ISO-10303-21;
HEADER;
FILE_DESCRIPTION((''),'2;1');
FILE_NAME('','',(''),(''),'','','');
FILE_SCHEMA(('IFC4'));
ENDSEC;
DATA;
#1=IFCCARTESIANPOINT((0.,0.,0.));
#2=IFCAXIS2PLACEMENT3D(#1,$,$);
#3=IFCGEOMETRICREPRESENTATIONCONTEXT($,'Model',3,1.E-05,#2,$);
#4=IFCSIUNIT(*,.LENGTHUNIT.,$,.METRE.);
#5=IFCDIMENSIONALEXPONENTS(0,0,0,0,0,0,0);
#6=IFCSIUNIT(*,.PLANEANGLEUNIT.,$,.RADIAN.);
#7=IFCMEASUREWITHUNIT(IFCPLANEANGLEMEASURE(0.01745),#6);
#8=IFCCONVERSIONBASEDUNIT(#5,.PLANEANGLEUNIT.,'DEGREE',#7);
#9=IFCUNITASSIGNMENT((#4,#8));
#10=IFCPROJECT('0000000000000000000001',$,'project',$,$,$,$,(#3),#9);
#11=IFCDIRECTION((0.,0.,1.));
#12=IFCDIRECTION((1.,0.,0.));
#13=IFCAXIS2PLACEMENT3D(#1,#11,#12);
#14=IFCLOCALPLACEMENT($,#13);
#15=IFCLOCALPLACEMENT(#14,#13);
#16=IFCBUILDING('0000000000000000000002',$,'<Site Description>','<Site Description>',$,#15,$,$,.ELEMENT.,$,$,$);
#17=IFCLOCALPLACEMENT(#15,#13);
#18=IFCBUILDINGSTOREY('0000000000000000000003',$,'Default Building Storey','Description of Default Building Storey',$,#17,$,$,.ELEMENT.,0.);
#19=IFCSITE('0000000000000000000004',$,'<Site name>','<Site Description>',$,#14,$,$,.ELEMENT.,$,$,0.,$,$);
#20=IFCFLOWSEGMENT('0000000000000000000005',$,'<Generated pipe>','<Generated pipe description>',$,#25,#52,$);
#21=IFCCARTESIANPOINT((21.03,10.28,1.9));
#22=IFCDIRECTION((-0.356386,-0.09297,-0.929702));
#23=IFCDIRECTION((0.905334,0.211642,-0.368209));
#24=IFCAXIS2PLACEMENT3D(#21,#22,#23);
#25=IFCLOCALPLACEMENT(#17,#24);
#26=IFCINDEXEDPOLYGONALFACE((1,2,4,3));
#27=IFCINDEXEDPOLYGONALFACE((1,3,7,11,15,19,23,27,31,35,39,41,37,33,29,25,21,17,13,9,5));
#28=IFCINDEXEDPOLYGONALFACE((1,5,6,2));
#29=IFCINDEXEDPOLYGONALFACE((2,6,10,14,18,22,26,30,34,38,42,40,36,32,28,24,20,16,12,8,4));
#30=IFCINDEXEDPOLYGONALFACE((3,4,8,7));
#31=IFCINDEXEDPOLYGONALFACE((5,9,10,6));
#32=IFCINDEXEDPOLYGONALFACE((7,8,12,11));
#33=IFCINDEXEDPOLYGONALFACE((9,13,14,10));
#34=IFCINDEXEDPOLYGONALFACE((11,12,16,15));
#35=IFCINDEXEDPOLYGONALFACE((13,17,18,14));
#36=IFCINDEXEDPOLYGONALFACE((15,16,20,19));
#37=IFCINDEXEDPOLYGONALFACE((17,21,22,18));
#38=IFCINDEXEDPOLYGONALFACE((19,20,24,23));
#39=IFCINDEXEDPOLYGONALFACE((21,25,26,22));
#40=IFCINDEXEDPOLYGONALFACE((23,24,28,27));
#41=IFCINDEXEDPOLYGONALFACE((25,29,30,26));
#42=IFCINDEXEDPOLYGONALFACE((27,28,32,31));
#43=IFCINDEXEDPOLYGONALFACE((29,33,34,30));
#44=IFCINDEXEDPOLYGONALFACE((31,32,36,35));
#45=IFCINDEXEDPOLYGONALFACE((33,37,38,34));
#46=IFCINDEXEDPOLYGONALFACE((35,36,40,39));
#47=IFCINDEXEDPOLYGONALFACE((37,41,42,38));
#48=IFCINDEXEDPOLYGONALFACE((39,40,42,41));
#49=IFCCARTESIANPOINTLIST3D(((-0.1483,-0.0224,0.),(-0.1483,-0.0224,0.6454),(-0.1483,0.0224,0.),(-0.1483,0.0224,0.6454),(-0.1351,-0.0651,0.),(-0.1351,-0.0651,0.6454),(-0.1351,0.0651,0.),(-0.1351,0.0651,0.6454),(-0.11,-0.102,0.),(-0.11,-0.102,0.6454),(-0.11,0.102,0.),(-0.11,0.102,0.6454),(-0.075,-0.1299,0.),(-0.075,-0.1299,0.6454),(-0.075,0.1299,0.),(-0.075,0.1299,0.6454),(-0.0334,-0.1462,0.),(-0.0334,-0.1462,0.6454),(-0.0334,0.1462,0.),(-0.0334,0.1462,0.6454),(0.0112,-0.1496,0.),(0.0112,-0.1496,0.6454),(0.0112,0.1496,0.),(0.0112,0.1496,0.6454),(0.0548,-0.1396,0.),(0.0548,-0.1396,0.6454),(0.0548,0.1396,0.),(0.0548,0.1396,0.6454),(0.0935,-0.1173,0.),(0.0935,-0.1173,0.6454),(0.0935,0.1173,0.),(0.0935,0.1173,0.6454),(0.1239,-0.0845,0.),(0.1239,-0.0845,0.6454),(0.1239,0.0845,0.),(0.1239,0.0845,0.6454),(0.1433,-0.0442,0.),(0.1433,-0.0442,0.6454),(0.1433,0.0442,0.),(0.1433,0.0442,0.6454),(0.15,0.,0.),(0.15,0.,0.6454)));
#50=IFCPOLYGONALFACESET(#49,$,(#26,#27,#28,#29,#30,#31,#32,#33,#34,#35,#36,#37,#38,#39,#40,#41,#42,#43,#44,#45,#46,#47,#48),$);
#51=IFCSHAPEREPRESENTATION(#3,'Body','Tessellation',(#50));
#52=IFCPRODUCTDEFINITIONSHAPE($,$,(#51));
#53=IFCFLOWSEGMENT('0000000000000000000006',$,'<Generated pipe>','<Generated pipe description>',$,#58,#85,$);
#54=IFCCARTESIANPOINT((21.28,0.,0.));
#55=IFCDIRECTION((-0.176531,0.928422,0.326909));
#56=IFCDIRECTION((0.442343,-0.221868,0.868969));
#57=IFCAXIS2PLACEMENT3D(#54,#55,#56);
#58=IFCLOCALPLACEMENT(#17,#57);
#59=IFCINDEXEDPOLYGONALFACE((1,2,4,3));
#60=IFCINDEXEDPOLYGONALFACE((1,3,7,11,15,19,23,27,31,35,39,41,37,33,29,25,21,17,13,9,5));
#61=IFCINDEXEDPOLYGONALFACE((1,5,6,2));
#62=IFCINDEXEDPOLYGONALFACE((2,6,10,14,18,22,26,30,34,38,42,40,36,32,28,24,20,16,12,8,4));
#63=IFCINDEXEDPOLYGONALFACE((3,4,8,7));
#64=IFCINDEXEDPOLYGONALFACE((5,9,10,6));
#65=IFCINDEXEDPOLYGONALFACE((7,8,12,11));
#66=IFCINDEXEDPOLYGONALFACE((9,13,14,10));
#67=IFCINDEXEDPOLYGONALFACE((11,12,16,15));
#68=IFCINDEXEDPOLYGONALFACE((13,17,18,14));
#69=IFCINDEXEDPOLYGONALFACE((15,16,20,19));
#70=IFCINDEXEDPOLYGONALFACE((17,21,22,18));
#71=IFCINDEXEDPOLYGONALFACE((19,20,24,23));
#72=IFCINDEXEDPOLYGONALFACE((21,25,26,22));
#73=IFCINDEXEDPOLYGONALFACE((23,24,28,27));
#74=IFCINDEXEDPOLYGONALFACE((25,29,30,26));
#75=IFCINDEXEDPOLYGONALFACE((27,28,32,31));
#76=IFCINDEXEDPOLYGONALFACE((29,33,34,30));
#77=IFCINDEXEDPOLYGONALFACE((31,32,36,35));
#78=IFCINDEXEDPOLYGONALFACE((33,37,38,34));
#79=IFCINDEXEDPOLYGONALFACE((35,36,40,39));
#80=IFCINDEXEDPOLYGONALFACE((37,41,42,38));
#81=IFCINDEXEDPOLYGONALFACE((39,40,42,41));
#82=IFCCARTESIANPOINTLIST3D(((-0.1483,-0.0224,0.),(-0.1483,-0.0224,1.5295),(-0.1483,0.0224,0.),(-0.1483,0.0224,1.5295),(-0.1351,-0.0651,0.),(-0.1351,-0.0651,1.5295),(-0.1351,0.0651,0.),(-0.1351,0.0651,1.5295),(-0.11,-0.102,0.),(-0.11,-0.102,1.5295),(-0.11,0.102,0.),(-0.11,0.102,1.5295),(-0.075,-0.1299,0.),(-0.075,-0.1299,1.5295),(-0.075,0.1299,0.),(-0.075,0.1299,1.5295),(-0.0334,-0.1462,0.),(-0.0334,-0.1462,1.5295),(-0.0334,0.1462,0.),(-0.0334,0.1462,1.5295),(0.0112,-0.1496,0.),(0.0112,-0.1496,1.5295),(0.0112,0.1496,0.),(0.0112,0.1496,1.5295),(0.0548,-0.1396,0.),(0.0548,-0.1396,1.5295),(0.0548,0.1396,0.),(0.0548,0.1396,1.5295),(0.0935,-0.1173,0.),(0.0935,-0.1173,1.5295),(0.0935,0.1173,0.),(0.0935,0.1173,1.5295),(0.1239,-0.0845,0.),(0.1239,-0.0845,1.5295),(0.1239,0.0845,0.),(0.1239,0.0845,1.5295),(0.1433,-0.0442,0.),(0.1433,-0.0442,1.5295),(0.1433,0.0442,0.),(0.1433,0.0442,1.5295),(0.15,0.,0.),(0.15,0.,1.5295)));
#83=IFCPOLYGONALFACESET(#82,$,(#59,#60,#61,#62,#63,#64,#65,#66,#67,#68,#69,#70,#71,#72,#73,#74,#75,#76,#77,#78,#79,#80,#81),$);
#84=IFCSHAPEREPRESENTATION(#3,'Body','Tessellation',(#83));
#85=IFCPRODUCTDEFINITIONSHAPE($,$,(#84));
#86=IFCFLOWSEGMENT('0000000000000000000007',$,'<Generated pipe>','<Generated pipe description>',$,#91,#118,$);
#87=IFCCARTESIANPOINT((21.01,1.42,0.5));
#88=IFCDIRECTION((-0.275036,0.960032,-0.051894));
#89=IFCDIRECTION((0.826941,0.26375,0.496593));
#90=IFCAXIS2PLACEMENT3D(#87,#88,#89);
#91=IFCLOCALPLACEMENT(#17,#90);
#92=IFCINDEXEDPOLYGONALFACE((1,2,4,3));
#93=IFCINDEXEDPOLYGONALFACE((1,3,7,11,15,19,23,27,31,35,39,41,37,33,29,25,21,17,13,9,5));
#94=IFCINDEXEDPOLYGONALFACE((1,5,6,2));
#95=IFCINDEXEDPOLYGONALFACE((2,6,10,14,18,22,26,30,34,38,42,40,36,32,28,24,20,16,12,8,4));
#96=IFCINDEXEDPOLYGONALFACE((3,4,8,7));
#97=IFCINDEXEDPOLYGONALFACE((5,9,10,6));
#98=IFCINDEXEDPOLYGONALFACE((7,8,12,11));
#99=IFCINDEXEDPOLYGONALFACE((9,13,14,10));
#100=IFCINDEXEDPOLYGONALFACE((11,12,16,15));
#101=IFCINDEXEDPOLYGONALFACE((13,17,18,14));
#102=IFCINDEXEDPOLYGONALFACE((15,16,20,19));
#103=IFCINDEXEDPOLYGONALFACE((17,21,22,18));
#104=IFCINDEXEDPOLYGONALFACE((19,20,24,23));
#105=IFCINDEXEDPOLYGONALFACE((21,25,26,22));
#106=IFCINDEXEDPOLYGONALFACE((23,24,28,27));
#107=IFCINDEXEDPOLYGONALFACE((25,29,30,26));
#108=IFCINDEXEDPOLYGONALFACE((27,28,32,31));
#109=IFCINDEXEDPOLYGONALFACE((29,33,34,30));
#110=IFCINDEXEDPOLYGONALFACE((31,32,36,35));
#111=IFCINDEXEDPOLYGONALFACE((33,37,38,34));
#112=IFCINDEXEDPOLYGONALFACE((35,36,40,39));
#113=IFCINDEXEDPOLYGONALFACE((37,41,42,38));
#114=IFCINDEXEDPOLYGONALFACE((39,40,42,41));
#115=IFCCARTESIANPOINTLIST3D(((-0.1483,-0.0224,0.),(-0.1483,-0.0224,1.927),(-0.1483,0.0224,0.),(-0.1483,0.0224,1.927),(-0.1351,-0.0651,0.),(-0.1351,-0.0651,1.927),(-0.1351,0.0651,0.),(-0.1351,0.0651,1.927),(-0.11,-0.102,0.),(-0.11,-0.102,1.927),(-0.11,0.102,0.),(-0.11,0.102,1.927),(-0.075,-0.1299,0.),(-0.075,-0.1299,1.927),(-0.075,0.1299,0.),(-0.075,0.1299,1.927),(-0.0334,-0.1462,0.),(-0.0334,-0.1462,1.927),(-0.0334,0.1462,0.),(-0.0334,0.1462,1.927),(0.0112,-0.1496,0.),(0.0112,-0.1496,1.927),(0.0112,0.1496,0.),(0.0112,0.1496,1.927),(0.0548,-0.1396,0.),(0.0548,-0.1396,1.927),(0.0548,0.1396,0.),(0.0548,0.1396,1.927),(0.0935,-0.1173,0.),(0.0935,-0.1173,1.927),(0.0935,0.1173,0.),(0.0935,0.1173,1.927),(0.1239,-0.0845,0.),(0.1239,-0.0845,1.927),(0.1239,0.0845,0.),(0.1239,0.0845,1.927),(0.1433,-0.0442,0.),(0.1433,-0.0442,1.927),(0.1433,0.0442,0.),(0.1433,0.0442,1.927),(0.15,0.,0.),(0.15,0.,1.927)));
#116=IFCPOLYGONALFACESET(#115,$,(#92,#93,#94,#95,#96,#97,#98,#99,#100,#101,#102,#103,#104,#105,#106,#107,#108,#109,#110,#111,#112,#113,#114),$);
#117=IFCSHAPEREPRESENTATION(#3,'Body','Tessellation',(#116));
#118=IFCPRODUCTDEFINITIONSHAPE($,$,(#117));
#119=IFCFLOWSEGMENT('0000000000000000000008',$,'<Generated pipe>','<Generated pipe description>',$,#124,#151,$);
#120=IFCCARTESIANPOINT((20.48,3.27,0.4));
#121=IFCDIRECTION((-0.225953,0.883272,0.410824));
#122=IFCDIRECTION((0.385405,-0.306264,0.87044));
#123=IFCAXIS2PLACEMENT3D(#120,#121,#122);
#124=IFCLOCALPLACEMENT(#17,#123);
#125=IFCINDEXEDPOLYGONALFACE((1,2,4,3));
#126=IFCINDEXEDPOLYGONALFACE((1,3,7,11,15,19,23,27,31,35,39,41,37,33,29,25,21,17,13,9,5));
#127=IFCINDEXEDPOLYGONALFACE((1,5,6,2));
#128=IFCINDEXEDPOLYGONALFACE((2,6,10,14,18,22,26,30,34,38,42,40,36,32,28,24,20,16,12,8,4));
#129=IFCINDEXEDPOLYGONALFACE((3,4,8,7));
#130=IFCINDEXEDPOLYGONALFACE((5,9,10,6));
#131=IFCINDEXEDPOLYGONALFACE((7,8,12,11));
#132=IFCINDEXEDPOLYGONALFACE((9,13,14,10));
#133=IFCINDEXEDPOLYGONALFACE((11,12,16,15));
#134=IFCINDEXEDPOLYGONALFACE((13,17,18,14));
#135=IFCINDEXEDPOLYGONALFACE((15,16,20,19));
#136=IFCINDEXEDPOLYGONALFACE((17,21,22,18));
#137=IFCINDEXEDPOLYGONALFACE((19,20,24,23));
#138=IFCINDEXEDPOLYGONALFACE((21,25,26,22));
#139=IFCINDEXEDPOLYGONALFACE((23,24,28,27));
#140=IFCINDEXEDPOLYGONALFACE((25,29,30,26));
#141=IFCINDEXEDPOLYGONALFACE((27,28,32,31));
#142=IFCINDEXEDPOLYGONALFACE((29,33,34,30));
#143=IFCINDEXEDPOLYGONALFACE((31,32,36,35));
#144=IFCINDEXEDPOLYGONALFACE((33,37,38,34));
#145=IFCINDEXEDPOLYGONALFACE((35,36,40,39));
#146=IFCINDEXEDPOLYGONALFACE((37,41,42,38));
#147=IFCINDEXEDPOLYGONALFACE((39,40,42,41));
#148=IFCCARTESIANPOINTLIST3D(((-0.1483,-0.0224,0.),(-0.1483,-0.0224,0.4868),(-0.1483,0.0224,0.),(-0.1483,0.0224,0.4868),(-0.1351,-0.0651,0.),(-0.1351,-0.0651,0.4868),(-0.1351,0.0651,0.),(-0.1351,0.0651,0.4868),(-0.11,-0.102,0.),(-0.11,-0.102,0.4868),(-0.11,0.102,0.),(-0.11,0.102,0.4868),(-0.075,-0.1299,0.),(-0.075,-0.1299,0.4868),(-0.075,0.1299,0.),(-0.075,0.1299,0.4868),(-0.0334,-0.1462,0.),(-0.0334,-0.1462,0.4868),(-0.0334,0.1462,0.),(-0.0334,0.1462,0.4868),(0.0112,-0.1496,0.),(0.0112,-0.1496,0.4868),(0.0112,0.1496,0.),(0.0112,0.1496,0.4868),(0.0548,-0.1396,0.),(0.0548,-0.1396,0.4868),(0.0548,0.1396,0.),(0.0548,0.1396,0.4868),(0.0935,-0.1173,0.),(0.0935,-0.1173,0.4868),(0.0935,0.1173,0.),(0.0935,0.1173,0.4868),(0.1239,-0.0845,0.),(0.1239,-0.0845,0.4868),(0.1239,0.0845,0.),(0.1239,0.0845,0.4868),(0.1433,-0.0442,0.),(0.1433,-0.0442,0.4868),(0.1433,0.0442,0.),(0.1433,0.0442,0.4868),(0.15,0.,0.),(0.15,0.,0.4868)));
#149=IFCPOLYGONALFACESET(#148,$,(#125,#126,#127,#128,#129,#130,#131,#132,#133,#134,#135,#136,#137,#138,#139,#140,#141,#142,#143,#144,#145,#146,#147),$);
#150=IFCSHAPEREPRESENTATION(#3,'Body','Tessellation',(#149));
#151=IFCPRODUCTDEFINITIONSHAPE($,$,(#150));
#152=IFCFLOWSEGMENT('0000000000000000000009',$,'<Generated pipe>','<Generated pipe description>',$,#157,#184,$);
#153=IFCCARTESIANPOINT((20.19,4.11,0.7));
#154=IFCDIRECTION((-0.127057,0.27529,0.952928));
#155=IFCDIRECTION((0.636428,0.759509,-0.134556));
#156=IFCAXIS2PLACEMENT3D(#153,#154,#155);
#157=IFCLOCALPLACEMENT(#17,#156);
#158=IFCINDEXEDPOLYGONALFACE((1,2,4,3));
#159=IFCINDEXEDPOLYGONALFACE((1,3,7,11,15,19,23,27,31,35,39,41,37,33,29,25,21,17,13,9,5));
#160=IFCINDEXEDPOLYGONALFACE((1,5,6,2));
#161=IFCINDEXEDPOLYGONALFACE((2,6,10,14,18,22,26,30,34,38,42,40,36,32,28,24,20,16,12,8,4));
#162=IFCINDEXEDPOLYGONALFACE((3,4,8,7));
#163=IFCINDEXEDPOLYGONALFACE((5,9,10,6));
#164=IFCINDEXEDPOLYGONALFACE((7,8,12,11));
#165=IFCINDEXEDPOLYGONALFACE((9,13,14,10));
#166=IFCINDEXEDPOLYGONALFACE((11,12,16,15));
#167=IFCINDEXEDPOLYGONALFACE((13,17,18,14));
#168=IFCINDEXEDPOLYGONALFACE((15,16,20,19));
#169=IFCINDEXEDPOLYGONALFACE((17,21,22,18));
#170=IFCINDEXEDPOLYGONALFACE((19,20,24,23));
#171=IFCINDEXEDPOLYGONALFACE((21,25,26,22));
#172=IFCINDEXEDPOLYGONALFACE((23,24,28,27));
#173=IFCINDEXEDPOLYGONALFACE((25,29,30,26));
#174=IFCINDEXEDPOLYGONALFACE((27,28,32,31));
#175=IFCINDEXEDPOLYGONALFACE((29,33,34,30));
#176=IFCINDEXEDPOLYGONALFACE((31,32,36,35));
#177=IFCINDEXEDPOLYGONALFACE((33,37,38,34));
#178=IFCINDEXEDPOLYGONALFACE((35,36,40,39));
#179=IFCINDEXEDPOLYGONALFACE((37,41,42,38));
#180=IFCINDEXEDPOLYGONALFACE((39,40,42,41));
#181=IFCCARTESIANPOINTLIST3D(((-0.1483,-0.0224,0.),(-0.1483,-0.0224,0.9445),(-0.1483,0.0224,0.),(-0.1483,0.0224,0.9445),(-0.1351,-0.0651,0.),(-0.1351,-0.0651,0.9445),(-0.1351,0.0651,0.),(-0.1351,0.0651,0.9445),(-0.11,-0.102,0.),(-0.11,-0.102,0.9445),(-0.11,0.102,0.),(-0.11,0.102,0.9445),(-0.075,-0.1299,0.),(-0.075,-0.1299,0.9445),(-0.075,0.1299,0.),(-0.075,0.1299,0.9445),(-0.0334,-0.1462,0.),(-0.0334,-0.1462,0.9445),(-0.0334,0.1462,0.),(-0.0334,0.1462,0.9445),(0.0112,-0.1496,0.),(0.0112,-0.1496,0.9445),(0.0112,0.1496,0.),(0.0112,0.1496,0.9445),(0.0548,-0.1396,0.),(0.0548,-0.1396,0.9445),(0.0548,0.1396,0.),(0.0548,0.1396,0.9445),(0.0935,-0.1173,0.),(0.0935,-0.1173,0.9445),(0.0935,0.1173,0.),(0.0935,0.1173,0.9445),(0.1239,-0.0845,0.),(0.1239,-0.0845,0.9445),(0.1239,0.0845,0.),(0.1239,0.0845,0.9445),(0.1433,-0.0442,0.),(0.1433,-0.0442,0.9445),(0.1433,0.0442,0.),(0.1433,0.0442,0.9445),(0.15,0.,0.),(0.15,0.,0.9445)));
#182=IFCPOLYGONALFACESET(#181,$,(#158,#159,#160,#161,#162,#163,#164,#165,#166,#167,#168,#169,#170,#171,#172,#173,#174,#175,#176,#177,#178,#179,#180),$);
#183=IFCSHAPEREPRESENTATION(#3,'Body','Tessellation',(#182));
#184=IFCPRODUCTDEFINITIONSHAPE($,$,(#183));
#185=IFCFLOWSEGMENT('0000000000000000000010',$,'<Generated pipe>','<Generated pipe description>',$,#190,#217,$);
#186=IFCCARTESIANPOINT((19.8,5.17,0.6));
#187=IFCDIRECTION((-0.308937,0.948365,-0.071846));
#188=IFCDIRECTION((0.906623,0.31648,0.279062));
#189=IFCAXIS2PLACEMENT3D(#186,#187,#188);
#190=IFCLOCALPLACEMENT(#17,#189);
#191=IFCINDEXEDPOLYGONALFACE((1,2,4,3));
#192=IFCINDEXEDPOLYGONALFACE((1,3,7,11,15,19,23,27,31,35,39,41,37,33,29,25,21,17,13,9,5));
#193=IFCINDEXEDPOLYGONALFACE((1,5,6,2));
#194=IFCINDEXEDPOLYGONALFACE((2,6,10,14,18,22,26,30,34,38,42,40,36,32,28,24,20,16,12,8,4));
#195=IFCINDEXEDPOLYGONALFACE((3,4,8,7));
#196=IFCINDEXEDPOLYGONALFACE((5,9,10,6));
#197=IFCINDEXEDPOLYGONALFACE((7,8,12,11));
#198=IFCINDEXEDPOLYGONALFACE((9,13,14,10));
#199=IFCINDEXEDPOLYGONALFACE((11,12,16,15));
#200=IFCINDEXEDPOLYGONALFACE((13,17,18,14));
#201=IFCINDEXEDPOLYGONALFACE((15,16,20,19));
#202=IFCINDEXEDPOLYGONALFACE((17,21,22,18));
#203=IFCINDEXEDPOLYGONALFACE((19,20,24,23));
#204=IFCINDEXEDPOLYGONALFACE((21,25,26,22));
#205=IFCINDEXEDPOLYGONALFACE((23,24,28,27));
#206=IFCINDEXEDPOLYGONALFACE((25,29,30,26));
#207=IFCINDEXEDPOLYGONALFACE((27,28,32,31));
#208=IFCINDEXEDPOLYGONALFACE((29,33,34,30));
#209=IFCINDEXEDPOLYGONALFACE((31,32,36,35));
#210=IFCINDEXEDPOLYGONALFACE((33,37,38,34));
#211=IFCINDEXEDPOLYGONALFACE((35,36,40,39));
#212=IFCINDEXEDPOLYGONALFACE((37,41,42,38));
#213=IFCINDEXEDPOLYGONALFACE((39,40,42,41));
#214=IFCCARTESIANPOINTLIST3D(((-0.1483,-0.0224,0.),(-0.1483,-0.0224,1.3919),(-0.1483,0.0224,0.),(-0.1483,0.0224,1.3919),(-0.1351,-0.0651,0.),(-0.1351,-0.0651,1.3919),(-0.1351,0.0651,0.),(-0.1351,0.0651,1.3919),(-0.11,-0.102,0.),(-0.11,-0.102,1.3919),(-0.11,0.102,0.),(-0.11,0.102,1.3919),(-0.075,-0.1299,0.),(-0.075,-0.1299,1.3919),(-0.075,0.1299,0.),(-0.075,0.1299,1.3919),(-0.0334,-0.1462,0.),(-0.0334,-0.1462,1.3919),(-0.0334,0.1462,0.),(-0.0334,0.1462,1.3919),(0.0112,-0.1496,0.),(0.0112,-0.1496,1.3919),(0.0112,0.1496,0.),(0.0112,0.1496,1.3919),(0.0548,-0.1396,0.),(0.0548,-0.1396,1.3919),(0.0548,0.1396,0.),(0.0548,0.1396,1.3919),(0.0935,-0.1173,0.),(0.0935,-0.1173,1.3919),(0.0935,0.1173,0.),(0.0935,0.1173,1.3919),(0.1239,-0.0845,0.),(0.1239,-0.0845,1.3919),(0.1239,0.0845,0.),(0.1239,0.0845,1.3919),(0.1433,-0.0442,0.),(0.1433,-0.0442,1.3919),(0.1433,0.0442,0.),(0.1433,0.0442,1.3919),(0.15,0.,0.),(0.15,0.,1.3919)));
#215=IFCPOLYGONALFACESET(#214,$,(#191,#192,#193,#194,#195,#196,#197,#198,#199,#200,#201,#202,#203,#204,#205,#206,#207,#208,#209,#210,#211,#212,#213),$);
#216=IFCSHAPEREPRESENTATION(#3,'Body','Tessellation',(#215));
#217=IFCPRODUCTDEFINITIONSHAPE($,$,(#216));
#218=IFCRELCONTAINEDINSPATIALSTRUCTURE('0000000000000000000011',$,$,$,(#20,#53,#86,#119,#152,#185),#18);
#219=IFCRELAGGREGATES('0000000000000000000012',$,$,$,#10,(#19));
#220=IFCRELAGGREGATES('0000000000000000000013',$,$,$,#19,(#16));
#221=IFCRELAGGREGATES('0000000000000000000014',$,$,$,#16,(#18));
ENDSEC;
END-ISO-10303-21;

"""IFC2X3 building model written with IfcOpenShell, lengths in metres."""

from ifc_helpers import new_model, entity, si_unit, converted_unit, frame, origin, origin_with_axes, origin_2d_with_axis, place, context, project, spatial, circle, extrude, element, save


model = new_model("IFC2X3")

# Units and contexts
model_context = context("Model", 3, precision=1e-05, world=origin())
ifc_project = project(units=[si_unit("LENGTHUNIT", "METRE"), converted_unit("PLANEANGLEUNIT", "DEGREE", entity("IfcPlaneAngleMeasure", 0.01745), si_unit("PLANEANGLEUNIT", "RADIAN"), dimensions=[0, 0, 0, 0, 0, 0, 0])], contexts=[model_context])

# Site, building, storey
site_placement = place(None, origin_with_axes())
site = spatial("IfcSite", under=ifc_project, at=site_placement, Name="<Site name>", Description="<Site Description>", CompositionType="ELEMENT", RefElevation=0.0)
building_placement = place(site_placement, origin_with_axes())
building = spatial("IfcBuilding", under=site, at=building_placement, Name="<Site Description>", Description="<Site Description>", CompositionType="ELEMENT")
storey_placement = place(building_placement, origin_with_axes())
storey = spatial("IfcBuildingStorey", under=building, at=storey_placement, Name="Default Building Storey", Description="Description of Default Building Storey", CompositionType="ELEMENT", Elevation=0.0)

# Flow segments
flow_segment_1_placement = place(storey_placement, frame((21.03, 10.28, 1.9), z_axis=(-0.356386, -0.09297, -0.929702), x_axis=(0.905334, 0.211642, -0.368209)))
element("IfcFlowSegment", 1, at=flow_segment_1_placement, inside=storey, Name="<Generated pipe>", Description="<Generated pipe description>", context=model_context, shape_type="SweptSolid", body=[
    extrude(circle(Radius=0.15, at=origin_2d_with_axis()), origin_with_axes(), (0.0, 0.0, 1.0), 0.6454),
])
flow_segment_2_placement = place(storey_placement, frame((21.28, 0.0, 0.0), z_axis=(-0.176531, 0.928422, 0.326909), x_axis=(0.442343, -0.221868, 0.868969)))
element("IfcFlowSegment", 2, at=flow_segment_2_placement, inside=storey, Name="<Generated pipe>", Description="<Generated pipe description>", context=model_context, shape_type="SweptSolid", body=[
    extrude(circle(Radius=0.15, at=origin_2d_with_axis()), origin_with_axes(), (0.0, 0.0, 1.0), 1.5295),
])
flow_segment_3_placement = place(storey_placement, frame((21.01, 1.42, 0.5), z_axis=(-0.275036, 0.960032, -0.051894), x_axis=(0.826941, 0.26375, 0.496593)))
element("IfcFlowSegment", 3, at=flow_segment_3_placement, inside=storey, Name="<Generated pipe>", Description="<Generated pipe description>", context=model_context, shape_type="SweptSolid", body=[
    extrude(circle(Radius=0.15, at=origin_2d_with_axis()), origin_with_axes(), (0.0, 0.0, 1.0), 1.927),
])
flow_segment_4_placement = place(storey_placement, frame((20.48, 3.27, 0.4), z_axis=(-0.225953, 0.883272, 0.410824), x_axis=(0.385405, -0.306264, 0.87044)))
element("IfcFlowSegment", 4, at=flow_segment_4_placement, inside=storey, Name="<Generated pipe>", Description="<Generated pipe description>", context=model_context, shape_type="SweptSolid", body=[
    extrude(circle(Radius=0.15, at=origin_2d_with_axis()), origin_with_axes(), (0.0, 0.0, 1.0), 0.4868),
])
flow_segment_5_placement = place(storey_placement, frame((20.19, 4.11, 0.7), z_axis=(-0.127057, 0.27529, 0.952928), x_axis=(0.636428, 0.759509, -0.134556)))
element("IfcFlowSegment", 5, at=flow_segment_5_placement, inside=storey, Name="<Generated pipe>", Description="<Generated pipe description>", context=model_context, shape_type="SweptSolid", body=[
    extrude(circle(Radius=0.15, at=origin_2d_with_axis()), origin_with_axes(), (0.0, 0.0, 1.0), 0.9445),
])
flow_segment_6_placement = place(storey_placement, frame((19.8, 5.17, 0.6), z_axis=(-0.308937, 0.948365, -0.071846), x_axis=(0.906623, 0.31648, 0.279062)))
element("IfcFlowSegment", 6, at=flow_segment_6_placement, inside=storey, Name="<Generated pipe>", Description="<Generated pipe description>", context=model_context, shape_type="SweptSolid", body=[
    extrude(circle(Radius=0.15, at=origin_2d_with_axis()), origin_with_axes(), (0.0, 0.0, 1.0), 1.3919),
])

save(model, "model.ifc")
